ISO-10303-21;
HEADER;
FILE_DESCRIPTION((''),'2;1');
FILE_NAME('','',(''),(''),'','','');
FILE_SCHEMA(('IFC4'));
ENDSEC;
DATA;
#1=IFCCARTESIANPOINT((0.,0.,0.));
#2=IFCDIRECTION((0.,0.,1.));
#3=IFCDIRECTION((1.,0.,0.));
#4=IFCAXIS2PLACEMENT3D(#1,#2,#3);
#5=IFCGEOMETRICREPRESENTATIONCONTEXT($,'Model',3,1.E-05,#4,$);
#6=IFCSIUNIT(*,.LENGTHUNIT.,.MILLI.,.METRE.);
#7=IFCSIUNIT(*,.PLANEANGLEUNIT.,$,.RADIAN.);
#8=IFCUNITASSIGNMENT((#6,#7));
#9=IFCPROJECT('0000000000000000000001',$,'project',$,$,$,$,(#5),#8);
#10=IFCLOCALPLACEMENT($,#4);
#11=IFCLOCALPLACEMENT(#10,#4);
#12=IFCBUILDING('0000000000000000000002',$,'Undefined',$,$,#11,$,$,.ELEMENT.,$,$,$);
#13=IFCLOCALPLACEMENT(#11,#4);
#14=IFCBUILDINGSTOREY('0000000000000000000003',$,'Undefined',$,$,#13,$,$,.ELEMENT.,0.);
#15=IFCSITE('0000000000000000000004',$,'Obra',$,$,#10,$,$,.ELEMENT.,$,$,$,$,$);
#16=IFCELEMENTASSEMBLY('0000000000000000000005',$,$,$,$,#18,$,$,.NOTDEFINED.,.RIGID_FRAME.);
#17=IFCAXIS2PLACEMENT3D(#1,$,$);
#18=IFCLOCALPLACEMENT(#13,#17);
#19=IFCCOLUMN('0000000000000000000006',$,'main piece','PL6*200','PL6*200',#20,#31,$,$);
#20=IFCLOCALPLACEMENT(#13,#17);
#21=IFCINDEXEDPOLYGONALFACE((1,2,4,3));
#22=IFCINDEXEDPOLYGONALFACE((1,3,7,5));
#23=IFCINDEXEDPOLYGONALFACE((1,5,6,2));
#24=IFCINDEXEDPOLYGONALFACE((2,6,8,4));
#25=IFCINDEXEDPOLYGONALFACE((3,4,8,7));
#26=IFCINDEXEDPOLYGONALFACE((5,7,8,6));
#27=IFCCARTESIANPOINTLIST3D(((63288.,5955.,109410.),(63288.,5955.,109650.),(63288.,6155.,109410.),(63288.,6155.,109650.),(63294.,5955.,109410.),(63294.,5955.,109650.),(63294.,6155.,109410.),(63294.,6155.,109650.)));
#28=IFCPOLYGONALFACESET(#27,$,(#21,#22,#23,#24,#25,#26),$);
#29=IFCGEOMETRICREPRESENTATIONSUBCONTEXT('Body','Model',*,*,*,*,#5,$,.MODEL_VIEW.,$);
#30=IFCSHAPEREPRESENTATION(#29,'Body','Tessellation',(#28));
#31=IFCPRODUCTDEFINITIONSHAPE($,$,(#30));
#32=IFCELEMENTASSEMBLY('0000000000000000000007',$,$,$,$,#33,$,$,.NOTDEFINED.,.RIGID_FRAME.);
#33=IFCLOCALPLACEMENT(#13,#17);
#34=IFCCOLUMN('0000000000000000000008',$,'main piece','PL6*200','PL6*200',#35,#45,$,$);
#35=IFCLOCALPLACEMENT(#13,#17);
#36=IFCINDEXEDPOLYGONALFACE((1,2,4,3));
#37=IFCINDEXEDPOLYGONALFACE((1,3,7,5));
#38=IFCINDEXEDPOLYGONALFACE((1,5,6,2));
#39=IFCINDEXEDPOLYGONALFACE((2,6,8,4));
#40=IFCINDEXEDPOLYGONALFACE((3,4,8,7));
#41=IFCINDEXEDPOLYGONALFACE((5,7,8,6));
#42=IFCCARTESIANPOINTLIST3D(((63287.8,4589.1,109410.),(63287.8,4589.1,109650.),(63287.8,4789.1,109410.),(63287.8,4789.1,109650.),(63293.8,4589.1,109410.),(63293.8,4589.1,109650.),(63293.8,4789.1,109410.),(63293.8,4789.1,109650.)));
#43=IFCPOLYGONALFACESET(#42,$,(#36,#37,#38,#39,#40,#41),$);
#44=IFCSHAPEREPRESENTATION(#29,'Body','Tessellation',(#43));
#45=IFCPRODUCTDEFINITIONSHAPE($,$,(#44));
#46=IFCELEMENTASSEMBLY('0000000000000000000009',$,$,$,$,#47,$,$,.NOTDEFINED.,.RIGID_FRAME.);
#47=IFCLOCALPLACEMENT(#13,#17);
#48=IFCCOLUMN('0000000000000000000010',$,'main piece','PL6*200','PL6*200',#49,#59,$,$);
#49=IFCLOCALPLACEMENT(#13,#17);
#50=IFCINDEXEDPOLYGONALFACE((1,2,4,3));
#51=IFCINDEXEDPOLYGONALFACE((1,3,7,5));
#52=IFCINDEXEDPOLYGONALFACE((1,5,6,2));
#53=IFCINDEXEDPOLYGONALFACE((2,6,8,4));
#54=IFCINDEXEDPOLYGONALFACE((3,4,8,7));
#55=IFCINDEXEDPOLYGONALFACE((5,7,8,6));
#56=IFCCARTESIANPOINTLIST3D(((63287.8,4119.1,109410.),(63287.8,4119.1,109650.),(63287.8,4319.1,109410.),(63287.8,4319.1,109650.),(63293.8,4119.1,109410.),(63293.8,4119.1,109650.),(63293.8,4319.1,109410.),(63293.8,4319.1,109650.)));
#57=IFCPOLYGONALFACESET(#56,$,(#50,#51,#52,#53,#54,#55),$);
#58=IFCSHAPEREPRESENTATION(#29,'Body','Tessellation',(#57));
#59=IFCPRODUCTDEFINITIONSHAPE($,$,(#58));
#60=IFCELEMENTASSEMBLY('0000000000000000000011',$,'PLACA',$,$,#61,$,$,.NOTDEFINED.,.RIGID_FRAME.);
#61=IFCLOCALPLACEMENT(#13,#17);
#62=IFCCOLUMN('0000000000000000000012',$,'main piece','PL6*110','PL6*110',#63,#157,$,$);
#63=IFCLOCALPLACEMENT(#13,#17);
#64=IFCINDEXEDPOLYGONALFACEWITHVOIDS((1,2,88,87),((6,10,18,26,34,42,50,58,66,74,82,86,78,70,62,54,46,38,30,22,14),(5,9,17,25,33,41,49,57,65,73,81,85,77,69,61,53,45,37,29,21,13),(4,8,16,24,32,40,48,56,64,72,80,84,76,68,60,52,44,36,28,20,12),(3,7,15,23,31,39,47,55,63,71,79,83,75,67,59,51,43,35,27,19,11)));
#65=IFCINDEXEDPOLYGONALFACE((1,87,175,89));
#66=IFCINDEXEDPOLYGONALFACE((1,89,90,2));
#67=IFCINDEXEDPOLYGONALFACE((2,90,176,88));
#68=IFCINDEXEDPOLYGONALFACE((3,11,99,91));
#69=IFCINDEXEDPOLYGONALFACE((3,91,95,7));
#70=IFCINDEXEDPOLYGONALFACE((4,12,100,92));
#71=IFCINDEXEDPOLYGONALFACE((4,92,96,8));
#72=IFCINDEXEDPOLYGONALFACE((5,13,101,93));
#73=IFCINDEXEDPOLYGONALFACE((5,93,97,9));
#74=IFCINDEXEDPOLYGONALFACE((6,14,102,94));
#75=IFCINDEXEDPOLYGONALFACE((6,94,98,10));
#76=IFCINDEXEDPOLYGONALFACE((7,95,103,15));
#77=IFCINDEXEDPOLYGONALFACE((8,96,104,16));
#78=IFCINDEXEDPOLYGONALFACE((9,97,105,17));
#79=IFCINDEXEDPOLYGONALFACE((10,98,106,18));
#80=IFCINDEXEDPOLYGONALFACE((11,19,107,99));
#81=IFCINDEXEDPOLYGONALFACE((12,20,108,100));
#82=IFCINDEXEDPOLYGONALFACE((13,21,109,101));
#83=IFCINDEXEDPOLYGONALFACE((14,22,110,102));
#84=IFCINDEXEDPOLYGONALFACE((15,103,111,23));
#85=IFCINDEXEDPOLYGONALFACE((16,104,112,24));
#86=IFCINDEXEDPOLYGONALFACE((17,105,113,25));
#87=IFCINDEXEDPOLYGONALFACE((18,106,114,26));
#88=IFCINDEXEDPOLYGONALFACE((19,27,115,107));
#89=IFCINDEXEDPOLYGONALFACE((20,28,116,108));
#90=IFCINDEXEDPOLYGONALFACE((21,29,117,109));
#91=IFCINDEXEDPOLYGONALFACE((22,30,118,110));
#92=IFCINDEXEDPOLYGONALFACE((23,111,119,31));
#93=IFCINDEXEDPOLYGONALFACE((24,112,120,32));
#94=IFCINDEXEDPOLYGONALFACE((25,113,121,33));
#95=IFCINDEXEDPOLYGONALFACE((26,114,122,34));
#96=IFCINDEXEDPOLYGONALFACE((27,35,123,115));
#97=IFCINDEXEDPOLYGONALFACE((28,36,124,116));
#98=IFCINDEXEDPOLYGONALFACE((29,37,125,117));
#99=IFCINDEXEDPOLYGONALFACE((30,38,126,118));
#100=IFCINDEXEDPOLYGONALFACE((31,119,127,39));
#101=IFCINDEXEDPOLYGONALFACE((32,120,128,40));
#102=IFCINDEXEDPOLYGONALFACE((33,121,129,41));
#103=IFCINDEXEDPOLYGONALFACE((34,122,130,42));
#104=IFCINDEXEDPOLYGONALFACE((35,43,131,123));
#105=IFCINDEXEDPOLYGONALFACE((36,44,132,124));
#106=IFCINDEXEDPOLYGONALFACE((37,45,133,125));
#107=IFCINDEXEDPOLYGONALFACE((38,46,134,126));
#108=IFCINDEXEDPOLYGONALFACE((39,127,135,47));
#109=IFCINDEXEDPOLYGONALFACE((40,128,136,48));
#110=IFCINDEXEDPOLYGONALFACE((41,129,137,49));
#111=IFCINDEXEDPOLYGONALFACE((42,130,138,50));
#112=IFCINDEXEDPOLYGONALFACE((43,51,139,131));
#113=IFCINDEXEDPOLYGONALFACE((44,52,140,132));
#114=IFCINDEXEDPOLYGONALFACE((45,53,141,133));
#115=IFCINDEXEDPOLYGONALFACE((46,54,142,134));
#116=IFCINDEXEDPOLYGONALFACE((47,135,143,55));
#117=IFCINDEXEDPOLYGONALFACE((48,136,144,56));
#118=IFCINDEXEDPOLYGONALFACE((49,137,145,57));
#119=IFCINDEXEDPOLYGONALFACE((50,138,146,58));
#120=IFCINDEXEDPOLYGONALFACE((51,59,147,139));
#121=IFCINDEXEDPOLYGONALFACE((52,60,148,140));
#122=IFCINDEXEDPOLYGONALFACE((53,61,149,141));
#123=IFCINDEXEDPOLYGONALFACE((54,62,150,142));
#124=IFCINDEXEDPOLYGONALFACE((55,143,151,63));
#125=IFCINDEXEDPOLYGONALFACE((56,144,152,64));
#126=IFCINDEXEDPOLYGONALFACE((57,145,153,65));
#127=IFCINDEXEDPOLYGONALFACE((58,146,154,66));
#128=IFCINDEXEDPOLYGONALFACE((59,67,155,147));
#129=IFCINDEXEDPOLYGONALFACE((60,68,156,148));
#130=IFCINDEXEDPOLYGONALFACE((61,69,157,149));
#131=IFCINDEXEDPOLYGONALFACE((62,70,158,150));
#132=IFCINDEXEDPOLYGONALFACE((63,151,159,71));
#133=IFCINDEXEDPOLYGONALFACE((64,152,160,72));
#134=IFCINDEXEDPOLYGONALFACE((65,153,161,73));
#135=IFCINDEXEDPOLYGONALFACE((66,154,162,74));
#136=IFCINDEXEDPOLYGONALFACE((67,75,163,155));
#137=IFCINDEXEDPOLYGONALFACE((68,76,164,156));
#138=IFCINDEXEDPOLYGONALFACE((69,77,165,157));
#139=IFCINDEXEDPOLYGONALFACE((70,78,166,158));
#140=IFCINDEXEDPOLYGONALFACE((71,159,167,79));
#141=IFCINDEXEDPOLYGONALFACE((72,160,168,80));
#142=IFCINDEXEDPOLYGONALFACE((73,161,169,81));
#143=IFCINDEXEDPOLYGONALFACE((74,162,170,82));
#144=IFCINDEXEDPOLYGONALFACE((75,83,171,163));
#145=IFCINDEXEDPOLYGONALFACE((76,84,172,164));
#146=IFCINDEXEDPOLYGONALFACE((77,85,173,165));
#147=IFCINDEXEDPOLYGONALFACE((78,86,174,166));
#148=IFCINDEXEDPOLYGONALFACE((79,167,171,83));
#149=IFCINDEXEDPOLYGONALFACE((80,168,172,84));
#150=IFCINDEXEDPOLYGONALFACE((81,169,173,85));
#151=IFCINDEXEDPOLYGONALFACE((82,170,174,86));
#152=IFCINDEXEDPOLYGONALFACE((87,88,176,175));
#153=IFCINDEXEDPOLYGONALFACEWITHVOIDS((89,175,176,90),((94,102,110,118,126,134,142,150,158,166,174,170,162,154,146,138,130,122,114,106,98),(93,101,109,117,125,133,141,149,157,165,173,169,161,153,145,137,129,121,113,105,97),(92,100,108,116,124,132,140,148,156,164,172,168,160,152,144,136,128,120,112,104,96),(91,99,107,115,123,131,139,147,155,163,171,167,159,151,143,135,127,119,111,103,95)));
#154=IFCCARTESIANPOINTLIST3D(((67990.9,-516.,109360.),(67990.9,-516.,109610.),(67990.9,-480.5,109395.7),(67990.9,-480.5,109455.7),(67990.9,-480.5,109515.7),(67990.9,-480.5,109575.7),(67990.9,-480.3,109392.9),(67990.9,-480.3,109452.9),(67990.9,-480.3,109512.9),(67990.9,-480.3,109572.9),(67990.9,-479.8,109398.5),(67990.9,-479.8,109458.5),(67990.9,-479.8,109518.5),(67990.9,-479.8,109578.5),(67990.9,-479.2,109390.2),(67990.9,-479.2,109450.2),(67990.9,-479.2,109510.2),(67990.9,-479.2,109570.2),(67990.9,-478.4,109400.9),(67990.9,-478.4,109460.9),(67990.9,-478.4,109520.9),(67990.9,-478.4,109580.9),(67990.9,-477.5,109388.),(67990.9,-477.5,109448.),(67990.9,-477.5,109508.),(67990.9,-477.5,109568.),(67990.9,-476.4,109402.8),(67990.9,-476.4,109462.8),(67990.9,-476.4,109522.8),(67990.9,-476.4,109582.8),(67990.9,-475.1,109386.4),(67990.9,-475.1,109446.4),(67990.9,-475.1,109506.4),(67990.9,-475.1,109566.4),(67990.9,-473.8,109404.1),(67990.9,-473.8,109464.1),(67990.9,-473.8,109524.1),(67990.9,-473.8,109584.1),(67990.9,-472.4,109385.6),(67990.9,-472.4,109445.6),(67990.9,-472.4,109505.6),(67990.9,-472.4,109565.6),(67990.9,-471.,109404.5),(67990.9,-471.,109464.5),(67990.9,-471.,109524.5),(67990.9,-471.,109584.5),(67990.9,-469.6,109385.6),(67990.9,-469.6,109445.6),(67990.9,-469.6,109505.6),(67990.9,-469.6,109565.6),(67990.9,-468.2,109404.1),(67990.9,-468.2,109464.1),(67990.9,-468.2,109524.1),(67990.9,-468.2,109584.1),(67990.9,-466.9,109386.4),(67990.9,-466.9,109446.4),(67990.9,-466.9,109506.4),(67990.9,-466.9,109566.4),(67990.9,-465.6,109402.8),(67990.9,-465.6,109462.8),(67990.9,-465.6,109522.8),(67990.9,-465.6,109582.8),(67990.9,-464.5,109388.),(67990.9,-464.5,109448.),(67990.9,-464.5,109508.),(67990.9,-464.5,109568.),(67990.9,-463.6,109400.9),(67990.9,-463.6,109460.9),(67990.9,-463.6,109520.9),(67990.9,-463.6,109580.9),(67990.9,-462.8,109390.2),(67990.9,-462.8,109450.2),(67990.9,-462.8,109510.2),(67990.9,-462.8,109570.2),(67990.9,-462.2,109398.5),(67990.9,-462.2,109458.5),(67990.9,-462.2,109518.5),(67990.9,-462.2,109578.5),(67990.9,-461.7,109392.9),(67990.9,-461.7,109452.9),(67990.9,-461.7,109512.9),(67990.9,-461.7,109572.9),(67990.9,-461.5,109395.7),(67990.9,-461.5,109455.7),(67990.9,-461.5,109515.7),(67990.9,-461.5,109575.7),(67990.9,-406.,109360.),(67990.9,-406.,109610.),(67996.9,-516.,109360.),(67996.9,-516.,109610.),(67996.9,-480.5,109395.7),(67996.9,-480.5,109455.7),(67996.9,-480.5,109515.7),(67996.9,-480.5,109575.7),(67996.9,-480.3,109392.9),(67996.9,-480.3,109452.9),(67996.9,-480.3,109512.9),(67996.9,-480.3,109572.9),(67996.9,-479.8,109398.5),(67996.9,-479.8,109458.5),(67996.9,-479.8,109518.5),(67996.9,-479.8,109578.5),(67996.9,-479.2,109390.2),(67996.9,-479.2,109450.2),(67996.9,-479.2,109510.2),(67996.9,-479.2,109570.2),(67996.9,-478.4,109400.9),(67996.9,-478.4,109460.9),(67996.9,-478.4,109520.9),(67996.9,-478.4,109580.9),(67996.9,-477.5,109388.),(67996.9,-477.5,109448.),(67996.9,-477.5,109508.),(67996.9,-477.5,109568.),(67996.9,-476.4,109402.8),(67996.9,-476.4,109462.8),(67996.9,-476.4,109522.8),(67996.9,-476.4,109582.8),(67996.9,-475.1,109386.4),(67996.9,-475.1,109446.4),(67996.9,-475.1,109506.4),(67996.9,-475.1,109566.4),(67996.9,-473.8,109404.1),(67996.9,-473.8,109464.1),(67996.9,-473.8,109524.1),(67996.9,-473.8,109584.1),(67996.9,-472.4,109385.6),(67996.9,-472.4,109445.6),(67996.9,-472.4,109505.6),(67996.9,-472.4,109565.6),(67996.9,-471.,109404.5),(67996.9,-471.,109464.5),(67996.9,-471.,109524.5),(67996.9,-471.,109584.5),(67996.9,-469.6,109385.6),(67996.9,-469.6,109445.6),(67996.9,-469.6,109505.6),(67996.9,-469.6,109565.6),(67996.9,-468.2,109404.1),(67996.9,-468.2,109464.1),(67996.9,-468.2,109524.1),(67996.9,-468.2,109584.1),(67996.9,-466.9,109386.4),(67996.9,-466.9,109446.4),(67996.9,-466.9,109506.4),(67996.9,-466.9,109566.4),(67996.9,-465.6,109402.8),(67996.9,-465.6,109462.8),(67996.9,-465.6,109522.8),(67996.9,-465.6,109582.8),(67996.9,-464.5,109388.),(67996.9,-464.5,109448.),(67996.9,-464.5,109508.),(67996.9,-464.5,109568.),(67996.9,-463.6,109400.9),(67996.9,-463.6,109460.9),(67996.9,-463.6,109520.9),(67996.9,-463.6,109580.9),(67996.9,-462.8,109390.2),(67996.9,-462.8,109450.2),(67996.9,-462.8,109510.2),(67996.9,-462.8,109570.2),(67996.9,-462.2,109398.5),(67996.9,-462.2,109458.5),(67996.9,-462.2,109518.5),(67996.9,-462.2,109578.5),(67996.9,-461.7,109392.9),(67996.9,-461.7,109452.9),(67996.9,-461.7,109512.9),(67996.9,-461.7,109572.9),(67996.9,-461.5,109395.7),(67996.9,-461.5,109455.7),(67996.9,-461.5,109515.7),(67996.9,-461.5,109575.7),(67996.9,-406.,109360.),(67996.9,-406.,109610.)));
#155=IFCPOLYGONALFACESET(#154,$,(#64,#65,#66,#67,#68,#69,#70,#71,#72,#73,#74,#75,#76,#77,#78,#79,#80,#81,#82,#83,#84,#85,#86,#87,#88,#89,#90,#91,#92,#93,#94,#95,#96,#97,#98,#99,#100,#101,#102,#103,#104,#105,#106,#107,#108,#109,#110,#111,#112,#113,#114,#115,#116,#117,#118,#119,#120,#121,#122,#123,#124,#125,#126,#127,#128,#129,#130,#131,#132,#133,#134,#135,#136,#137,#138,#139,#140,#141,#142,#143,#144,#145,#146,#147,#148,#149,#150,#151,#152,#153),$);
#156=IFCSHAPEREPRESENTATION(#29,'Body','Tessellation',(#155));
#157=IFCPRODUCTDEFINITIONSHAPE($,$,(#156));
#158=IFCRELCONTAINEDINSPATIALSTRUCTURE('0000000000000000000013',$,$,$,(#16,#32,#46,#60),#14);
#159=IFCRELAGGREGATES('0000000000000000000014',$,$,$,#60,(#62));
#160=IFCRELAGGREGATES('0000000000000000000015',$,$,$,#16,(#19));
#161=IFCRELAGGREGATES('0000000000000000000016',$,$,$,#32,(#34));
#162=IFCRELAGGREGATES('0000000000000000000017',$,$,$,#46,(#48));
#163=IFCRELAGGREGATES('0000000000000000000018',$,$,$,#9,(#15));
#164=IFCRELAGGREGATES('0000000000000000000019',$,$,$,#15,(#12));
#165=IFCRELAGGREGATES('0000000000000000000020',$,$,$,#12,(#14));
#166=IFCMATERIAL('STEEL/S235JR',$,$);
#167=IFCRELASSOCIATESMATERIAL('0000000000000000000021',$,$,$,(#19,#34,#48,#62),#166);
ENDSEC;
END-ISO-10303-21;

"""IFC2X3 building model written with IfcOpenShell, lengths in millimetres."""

from ifc_helpers import new_model, si_unit, frame, origin_with_axes, origin_2d_with_axis, place, context, subcontext, project, spatial, rectangle, circle, extrude, source, transform, mapped, material, element, aggregate, save


model = new_model("IFC2X3")

# Units and contexts
model_context = context("Model", 3, precision=1e-05, world=origin_with_axes())
body_context = subcontext(model_context, "Body", "Model", "MODEL_VIEW")
ifc_project = project(units=[si_unit("LENGTHUNIT", "METRE", prefix="MILLI"), si_unit("PLANEANGLEUNIT", "RADIAN")], contexts=[model_context])

# Site, building, storey
site_placement = place(None, origin_with_axes())
site = spatial("IfcSite", under=ifc_project, at=site_placement, Name="Obra", CompositionType="ELEMENT")
building_placement = place(site_placement, origin_with_axes())
building = spatial("IfcBuilding", under=site, at=building_placement, Name="Undefined", CompositionType="ELEMENT")
storey_placement = place(building_placement, origin_with_axes())
storey = spatial("IfcBuildingStorey", under=building, at=storey_placement, Name="Undefined", CompositionType="ELEMENT", Elevation=0.0)

# Element assemblies, columns
assembly_1_placement = place(storey_placement, origin_with_axes())
assembly_1 = element("IfcElementAssembly", 1, at=assembly_1_placement, inside=storey, AssemblyPlace="NOTDEFINED", PredefinedType="RIGID_FRAME")
ifc_material_1 = material(Name="STEEL/S235JR")
column_1_placement = place(assembly_1_placement, frame((63291.0, 6055.0, 109410.0), z_axis=(0.0, 0.0, 1.0), x_axis=(-0.000126, -1.0, 0.0)))
column_1 = element("IfcColumn", 2, at=column_1_placement, material=ifc_material_1, Name="main piece", Description="PL6*200", ObjectType="PL6*200", context=body_context, shape_type="SweptSolid", body=[
    extrude(rectangle(XDim=6.0, YDim=200.0, at=origin_2d_with_axis()), frame((0.0, 0.0, 240.0), z_axis=(0.0, 0.0, -1.0), x_axis=(0.0, 1.0, 0.0)), (0.0, 0.0, 1.0), 240.0),
])
assembly_2_placement = place(storey_placement, origin_with_axes())
assembly_2 = element("IfcElementAssembly", 3, at=assembly_2_placement, inside=storey, AssemblyPlace="NOTDEFINED", PredefinedType="RIGID_FRAME")
column_2_placement = place(assembly_2_placement, frame((63290.8, 4689.1, 109410.0), z_axis=(0.0, 0.0, 1.0), x_axis=(-0.000126, -1.0, 0.0)))
column_2 = element("IfcColumn", 4, at=column_2_placement, material=ifc_material_1, Name="main piece", Description="PL6*200", ObjectType="PL6*200", context=body_context, shape_type="SweptSolid", body=[
    extrude(rectangle(XDim=6.0, YDim=200.0, at=origin_2d_with_axis()), frame((0.0, 0.0, 240.0), z_axis=(0.0, 0.0, -1.0), x_axis=(0.0, 1.0, 0.0)), (0.0, 0.0, 1.0), 240.0),
])
assembly_3_placement = place(storey_placement, origin_with_axes())
assembly_3 = element("IfcElementAssembly", 5, at=assembly_3_placement, inside=storey, AssemblyPlace="NOTDEFINED", PredefinedType="RIGID_FRAME")
column_3_placement = place(assembly_3_placement, frame((63290.8, 4219.1, 109410.0), z_axis=(0.0, 0.0, 1.0), x_axis=(-0.000126, -1.0, 0.0)))
column_3 = element("IfcColumn", 6, at=column_3_placement, material=ifc_material_1, Name="main piece", Description="PL6*200", ObjectType="PL6*200", context=body_context, shape_type="SweptSolid", body=[
    extrude(rectangle(XDim=6.0, YDim=200.0, at=origin_2d_with_axis()), frame((0.0, 0.0, 240.0), z_axis=(0.0, 0.0, -1.0), x_axis=(0.0, 1.0, 0.0)), (0.0, 0.0, 1.0), 240.0),
])

# Element assembly, column, opening
assembly_4_placement = place(storey_placement, origin_with_axes())
assembly_4 = element("IfcElementAssembly", 7, at=assembly_4_placement, inside=storey, Name="PLACA", AssemblyPlace="NOTDEFINED", PredefinedType="RIGID_FRAME")
column_4_placement = place(assembly_4_placement, frame((67993.9, -461.0, 109360.0), z_axis=(0.0, 0.0, 1.0), x_axis=(0.0, 1.0, 0.0)))
column_4 = element("IfcColumn", 8, at=column_4_placement, material=ifc_material_1, Name="main piece", Description="PL6*110", ObjectType="PL6*110", context=body_context, shape_type="SweptSolid", body=[
    extrude(rectangle(XDim=6.0, YDim=110.0, at=origin_2d_with_axis()), frame((0.0, 0.0, 250.0), z_axis=(0.0, 0.0, -1.0), x_axis=(0.0, 1.0, 0.0)), (0.0, 0.0, 1.0), 250.0),
])
shared_shape_1 = source(origin_with_axes(), body_context, "Body", "SweptSolid", [
    extrude(circle(Radius=9.5, at=origin_2d_with_axis()), frame((0.0, -9.2, 0.0), z_axis=(0.0, 1.0, 0.0), x_axis=(1.0, 0.0, 0.0)), (0.0, 0.0, 1.0), 6.2),
])
opening_1_placement = place(assembly_4_placement, frame((68000.0, -471.0, 109395.0), z_axis=(0.0, 1.0, 0.0), x_axis=(0.0, 0.0, 1.0)))
element("IfcOpeningElement", 9, at=opening_1_placement, cuts=column_4, ObjectType="Opening", context=body_context, shape_type="MappedRepresentation", body=[
    mapped(shared_shape_1, transform((0.0, 0.0, 0.0))),
    mapped(shared_shape_1, transform((60.0, 0.0, 0.0))),
    mapped(shared_shape_1, transform((120.0, 0.0, 0.0))),
    mapped(shared_shape_1, transform((180.0, 0.0, 0.0))),
])
aggregate(assembly_4, [column_4])

aggregate(assembly_1, [column_1])
aggregate(assembly_2, [column_2])
aggregate(assembly_3, [column_3])

save(model, "model.ifc")
